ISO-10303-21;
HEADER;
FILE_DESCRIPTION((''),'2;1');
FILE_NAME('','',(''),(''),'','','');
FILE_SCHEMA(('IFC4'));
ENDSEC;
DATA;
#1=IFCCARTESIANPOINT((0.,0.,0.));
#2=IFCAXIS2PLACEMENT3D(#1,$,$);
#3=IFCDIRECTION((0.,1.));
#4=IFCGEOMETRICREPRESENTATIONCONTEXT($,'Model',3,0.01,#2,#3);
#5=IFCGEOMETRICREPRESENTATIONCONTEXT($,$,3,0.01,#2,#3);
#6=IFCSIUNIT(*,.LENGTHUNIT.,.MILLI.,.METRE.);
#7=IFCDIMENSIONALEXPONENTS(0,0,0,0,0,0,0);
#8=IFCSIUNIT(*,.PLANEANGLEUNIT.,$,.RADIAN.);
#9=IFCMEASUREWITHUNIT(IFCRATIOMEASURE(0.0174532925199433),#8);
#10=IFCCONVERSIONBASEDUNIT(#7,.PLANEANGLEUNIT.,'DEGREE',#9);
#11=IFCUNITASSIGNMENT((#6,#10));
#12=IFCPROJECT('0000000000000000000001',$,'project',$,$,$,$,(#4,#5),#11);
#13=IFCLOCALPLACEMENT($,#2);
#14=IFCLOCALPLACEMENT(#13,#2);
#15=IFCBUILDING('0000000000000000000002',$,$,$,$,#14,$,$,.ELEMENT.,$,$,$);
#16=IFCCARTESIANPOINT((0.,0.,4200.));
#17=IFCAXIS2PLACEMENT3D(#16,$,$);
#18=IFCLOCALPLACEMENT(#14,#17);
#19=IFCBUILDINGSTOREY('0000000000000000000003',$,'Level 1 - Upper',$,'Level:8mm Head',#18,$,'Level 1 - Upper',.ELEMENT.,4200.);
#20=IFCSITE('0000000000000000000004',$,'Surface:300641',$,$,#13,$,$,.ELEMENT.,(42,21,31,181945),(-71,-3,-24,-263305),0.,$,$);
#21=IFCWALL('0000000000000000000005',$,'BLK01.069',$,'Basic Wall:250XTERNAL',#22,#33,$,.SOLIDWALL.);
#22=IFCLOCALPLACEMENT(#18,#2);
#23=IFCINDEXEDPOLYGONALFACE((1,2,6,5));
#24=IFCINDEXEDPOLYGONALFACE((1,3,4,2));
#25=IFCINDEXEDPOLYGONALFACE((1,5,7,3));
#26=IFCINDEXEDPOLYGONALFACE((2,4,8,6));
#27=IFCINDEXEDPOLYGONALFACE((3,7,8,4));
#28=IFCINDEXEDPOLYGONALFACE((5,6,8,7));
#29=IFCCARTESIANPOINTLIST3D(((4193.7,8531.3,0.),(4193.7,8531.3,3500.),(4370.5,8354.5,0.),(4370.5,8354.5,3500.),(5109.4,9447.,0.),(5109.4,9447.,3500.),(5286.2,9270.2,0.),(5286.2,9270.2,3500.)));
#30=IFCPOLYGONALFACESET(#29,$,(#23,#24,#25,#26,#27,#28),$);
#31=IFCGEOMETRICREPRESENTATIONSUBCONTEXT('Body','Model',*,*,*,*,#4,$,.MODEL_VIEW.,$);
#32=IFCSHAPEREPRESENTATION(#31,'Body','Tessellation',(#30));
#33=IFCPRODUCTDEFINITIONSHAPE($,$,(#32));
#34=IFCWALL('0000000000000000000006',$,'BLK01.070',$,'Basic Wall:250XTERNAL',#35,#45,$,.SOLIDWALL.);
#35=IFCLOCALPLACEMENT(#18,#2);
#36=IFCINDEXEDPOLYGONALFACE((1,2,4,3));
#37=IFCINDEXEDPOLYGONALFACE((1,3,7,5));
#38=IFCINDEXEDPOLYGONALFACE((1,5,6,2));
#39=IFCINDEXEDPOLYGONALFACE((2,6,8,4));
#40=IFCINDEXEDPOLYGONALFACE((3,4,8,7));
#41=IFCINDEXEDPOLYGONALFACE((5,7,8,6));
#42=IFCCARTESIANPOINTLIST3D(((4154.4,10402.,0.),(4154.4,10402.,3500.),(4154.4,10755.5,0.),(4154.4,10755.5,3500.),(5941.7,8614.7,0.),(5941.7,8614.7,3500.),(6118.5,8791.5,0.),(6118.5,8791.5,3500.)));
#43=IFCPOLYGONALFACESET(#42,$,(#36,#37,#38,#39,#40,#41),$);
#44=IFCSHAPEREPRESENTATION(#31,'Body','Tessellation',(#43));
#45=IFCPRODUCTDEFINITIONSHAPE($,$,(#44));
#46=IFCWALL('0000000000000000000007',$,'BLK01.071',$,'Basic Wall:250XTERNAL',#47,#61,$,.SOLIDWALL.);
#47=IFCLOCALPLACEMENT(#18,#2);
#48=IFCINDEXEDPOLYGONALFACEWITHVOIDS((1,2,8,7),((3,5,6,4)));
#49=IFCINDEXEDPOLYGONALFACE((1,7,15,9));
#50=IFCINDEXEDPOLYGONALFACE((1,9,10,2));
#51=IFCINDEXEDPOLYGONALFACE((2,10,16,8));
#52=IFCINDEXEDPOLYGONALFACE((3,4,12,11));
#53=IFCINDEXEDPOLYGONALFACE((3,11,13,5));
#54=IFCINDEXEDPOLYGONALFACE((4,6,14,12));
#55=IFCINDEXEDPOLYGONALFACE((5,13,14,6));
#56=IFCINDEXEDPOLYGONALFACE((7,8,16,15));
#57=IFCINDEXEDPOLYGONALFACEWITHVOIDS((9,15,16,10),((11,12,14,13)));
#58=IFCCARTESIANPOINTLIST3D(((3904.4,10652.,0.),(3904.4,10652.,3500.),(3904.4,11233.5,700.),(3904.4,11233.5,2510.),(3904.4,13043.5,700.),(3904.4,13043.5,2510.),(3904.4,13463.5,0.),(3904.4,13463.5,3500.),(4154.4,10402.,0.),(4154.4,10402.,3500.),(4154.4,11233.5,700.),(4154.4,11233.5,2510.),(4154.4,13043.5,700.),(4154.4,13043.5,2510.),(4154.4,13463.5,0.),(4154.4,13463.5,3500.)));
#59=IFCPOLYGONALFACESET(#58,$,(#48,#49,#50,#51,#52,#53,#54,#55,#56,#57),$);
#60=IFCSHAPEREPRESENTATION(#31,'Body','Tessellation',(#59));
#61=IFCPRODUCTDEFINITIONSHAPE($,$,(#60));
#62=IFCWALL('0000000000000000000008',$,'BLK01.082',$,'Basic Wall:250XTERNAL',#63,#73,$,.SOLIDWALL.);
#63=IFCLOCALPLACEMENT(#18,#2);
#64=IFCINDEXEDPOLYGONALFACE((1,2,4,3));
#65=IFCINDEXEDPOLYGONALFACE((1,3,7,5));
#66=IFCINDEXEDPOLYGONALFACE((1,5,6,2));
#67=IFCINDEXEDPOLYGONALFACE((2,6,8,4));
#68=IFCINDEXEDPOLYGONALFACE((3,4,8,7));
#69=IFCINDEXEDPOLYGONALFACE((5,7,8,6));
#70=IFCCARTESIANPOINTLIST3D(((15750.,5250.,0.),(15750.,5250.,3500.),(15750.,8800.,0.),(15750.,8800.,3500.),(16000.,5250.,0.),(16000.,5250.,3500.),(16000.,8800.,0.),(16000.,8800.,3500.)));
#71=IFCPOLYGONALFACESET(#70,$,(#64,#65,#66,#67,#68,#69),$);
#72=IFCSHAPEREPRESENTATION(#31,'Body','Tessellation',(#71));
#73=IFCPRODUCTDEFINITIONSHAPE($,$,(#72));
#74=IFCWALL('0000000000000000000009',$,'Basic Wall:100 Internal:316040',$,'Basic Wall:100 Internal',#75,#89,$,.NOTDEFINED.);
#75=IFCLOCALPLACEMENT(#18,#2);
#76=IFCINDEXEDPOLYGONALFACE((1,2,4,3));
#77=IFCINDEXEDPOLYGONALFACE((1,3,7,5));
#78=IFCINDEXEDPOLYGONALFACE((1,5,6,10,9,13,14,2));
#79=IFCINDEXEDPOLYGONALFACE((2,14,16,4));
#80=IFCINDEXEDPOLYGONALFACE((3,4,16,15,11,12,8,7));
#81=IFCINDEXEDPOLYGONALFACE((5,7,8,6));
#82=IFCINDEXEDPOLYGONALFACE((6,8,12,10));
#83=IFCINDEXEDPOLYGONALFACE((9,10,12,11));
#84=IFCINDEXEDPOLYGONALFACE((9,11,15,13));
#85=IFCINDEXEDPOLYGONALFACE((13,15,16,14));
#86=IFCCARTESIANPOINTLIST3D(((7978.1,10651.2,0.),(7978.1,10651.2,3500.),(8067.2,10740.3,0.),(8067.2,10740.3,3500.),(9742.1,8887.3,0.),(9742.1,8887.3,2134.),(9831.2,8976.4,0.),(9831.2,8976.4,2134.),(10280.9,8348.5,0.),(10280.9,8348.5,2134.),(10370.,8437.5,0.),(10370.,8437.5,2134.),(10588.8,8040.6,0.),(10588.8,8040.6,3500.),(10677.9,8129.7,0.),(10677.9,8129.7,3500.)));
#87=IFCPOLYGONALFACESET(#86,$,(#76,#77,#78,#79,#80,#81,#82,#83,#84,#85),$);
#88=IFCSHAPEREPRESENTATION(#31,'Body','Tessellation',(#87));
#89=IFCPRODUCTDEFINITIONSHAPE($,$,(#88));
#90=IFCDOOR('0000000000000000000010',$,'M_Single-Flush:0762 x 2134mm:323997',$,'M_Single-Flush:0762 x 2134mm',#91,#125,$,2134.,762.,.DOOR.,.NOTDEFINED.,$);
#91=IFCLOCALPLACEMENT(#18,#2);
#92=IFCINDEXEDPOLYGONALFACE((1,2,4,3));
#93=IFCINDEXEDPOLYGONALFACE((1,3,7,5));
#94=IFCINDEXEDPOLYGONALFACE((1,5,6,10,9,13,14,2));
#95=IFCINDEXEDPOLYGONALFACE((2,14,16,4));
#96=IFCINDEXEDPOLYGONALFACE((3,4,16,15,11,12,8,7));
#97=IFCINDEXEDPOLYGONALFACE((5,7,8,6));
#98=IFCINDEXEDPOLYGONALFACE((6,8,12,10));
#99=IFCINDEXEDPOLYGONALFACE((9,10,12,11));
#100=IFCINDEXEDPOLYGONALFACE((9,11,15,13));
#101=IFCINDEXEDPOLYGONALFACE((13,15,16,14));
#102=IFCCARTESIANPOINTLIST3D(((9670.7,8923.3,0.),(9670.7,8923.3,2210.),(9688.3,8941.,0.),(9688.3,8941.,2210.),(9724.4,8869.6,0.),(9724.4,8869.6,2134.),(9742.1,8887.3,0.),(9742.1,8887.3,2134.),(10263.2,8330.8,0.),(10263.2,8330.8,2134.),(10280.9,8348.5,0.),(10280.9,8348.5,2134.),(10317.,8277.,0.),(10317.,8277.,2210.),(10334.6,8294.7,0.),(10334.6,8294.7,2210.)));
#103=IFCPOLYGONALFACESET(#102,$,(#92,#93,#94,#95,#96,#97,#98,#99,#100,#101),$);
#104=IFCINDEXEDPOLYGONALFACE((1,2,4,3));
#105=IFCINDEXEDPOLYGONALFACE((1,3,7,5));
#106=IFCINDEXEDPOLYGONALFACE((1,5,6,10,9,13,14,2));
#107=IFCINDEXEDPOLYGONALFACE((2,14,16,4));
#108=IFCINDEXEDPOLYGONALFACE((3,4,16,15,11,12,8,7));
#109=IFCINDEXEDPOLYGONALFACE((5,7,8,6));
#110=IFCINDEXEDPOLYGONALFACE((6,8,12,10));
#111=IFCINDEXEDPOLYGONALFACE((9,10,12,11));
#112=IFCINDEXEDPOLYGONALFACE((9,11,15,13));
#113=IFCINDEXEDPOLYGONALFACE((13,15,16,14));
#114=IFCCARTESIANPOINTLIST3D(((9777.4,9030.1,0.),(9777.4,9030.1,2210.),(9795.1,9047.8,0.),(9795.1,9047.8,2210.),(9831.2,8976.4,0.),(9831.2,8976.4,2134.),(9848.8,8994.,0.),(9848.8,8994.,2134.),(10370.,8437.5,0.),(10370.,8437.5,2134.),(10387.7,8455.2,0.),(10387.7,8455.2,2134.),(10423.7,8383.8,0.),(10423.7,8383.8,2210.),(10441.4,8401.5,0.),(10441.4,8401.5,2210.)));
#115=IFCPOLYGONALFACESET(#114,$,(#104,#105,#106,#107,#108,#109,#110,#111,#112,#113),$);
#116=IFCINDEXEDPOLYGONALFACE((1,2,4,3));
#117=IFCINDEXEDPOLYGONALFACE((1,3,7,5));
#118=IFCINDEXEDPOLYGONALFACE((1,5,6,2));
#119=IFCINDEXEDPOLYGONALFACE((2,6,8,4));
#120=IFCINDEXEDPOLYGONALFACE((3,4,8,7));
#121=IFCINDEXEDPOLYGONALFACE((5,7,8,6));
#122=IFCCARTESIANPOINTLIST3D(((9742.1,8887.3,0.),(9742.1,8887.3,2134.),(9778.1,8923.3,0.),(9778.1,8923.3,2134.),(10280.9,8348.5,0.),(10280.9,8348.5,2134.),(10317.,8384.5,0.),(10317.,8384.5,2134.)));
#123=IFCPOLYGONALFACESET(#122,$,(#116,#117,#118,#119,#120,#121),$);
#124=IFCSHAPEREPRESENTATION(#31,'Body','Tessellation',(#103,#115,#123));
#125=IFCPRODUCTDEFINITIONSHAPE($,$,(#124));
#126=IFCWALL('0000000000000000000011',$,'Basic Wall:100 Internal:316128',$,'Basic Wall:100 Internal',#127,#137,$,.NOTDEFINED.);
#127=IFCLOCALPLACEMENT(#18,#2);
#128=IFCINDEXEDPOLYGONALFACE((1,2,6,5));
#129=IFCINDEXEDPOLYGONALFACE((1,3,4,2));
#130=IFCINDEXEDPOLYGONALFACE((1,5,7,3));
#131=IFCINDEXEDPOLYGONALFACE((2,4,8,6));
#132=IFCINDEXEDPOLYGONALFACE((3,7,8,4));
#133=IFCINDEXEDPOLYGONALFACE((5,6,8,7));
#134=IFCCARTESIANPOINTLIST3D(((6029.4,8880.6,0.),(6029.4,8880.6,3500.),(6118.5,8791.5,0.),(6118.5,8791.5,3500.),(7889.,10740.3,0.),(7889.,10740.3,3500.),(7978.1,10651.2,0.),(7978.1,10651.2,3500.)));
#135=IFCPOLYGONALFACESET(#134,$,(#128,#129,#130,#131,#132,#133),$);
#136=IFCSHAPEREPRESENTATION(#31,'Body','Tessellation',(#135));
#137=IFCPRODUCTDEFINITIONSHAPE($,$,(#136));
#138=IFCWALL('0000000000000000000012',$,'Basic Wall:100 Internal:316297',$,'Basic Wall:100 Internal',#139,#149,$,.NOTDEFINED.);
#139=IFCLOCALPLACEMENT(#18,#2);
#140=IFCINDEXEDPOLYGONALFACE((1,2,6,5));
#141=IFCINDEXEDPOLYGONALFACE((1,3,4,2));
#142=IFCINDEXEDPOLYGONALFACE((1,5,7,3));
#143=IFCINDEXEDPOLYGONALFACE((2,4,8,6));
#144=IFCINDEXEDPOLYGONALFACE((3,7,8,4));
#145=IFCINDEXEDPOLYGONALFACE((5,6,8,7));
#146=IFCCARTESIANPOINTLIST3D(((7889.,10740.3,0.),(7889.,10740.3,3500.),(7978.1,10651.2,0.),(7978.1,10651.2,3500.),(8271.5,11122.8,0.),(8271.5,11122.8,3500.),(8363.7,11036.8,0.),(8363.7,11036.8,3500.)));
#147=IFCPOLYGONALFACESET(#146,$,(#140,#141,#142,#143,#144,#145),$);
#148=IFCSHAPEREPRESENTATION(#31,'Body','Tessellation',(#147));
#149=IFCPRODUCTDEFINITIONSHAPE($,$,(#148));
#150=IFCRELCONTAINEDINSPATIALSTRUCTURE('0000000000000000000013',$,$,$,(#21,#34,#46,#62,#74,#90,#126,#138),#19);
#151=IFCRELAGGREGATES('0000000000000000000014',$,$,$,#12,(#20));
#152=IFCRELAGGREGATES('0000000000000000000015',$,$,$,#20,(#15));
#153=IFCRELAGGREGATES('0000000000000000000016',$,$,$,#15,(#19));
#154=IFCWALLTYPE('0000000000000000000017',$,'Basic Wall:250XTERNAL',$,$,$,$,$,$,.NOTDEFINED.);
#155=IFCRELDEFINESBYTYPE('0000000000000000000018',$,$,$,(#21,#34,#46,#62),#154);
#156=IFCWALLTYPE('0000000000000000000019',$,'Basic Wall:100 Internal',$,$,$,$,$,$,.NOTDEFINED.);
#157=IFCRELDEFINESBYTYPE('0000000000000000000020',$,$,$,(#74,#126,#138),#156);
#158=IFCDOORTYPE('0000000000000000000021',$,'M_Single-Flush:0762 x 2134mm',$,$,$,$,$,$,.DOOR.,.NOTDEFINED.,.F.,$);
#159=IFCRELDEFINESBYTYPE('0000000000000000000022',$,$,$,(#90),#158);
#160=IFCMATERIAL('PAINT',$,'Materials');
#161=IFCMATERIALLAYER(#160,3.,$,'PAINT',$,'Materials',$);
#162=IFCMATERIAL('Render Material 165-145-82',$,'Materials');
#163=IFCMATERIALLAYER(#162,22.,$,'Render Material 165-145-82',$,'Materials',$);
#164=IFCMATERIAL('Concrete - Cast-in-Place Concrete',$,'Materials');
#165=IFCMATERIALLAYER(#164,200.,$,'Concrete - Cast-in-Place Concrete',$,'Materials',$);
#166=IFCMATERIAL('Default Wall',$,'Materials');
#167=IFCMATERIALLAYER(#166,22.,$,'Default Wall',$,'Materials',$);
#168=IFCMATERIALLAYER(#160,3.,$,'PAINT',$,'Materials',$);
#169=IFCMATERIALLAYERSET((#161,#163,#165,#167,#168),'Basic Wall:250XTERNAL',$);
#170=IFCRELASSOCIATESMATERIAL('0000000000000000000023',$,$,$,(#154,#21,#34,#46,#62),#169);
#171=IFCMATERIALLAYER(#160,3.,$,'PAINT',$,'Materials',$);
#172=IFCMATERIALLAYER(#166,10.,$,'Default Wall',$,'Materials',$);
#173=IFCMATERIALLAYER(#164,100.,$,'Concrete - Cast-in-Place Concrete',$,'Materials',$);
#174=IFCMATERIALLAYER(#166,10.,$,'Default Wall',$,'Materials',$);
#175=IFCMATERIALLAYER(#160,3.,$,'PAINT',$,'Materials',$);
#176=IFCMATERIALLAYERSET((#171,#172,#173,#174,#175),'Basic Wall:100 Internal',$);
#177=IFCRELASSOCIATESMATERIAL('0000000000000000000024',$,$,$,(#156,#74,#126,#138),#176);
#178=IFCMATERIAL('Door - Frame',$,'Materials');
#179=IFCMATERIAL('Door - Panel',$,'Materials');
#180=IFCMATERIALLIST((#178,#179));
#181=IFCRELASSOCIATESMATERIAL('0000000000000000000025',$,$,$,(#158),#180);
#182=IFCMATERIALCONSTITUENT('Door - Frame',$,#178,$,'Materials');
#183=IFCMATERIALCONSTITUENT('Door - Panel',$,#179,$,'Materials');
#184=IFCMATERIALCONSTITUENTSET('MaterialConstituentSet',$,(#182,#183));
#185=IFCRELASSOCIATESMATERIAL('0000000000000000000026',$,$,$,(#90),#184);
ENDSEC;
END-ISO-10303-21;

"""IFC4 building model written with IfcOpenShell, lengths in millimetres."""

from ifc_helpers import new_model, entity, si_unit, converted_unit, direction, frame, frame_2d, origin, place, context, subcontext, project, spatial, polyline, rectangle, outline, extrude, clip, halfspace, source, transform, mapped, material, material_list, layer, layer_set, layer_usage, constituent, constituent_set, type_object, type_shapes, element, fill, save


model = new_model("IFC4")

# Units and contexts
model_context = context("Model", 3, precision=0.01, world=origin(), true_north=direction((0.0, 1.0)))
context_of_model = context(None, 3, precision=0.01, world=origin(), true_north=direction((0.0, 1.0)))
body_context = subcontext(model_context, "Body", "Model", "MODEL_VIEW")
ifc_project = project(units=[si_unit("LENGTHUNIT", "METRE", prefix="MILLI"), converted_unit("PLANEANGLEUNIT", "DEGREE", entity("IfcRatioMeasure", 0.0174532925199433), si_unit("PLANEANGLEUNIT", "RADIAN"), dimensions=[0, 0, 0, 0, 0, 0, 0])], contexts=[model_context, context_of_model])

# Site, building, storey
site_placement = place(None, origin())
site = spatial("IfcSite", under=ifc_project, at=site_placement, Name="Surface:300641", CompositionType="ELEMENT", RefLatitude=(42, 21, 31, 181945), RefLongitude=(-71, -3, -24, -263305), RefElevation=0.0)
building_placement = place(site_placement, origin())
building = spatial("IfcBuilding", under=site, at=building_placement, CompositionType="ELEMENT")
storey_placement = place(building_placement, frame((0.0, 0.0, 4200.0)))
storey = spatial("IfcBuildingStorey", under=building, at=storey_placement, Name="Level 1 - Upper", ObjectType="Level:8mm Head", LongName="Level 1 - Upper", CompositionType="ELEMENT", Elevation=4200.0)

# Shared definitions
ifc_material_1 = material(Name="PAINT", Category="Materials")
ifc_layer_1 = layer(ifc_material_1, 3.0, Name="PAINT", Category="Materials")
ifc_material_2 = material(Name="Render Material 165-145-82", Category="Materials")
ifc_layer_2 = layer(ifc_material_2, 22.0, Name="Render Material 165-145-82", Category="Materials")
ifc_material_3 = material(Name="Concrete - Cast-in-Place Concrete", Category="Materials")
ifc_layer_3 = layer(ifc_material_3, 200.0, Name="Concrete - Cast-in-Place Concrete", Category="Materials")
ifc_material_4 = material(Name="Default Wall", Category="Materials")
ifc_layer_4 = layer(ifc_material_4, 22.0, Name="Default Wall", Category="Materials")
ifc_layer_5 = layer(ifc_material_1, 3.0, Name="PAINT", Category="Materials")
ifc_layer_set_1 = layer_set([ifc_layer_1, ifc_layer_2, ifc_layer_3, ifc_layer_4, ifc_layer_5], Name="Basic Wall:250XTERNAL")
wall_type_1 = type_object("IfcWallType", Name="Basic Wall:250XTERNAL", PredefinedType="NOTDEFINED", material=ifc_layer_set_1)

# Walls
ifc_layer_usage_1 = layer_usage(ifc_layer_set_1, "AXIS2", "NEGATIVE", 125.0)
wall_1_placement = place(storey_placement, frame((4282.1, 8442.9, 0.0), z_axis=(0.0, 0.0, 1.0), x_axis=(0.707107, 0.707107, 0.0)))
element("IfcWall", 1, at=wall_1_placement, inside=storey, type_object=wall_type_1, material=ifc_layer_usage_1, Name="BLK01.069", ObjectType="Basic Wall:250XTERNAL", PredefinedType="SOLIDWALL", context=body_context, shape_type="Clipping", body=[
    clip(extrude(rectangle(XDim=1295.0, YDim=250.0, at=frame_2d((647.5, 0.0), x_axis=(-1.0, 0.0))), origin(), (0.0, 0.0, 1.0), 3500.0), halfspace(origin(), True)),
])
ifc_layer_usage_2 = layer_usage(ifc_layer_set_1, "AXIS2", "NEGATIVE", 125.0)
wall_2_placement = place(storey_placement, frame((6030.1, 8703.1, 0.0), z_axis=(0.0, 0.0, 1.0), x_axis=(-0.707107, 0.707107, 0.0)))
element("IfcWall", 2, at=wall_2_placement, inside=storey, type_object=wall_type_1, material=ifc_layer_usage_2, Name="BLK01.070", ObjectType="Basic Wall:250XTERNAL", PredefinedType="SOLIDWALL", context=body_context, shape_type="Clipping", body=[
    clip(extrude(outline(polyline([(2777.5, -125.0), (2527.5, 125.0), (1177.0, 125.0), (927.0, 125.0), (0.0, 125.0), (0.0, -125.0), (126.0, -125.0), (2777.5, -125.0)])), origin(), (0.0, 0.0, 1.0), 3500.0), halfspace(origin(), True)),
])

# Wall, opening
ifc_layer_usage_3 = layer_usage(ifc_layer_set_1, "AXIS2", "NEGATIVE", 125.0)
wall_3_placement = place(storey_placement, frame((4029.4, 10402.0, 0.0), z_axis=(0.0, 0.0, 1.0), x_axis=(0.0, 1.0, 0.0)))
wall_3 = element("IfcWall", 3, at=wall_3_placement, inside=storey, type_object=wall_type_1, material=ifc_layer_usage_3, Name="BLK01.071", ObjectType="Basic Wall:250XTERNAL", PredefinedType="SOLIDWALL", context=body_context, shape_type="Clipping", body=[
    clip(extrude(outline(polyline([(3061.5, -125.0), (3061.5, 125.0), (250.0, 125.0), (0.0, -125.0), (353.6, -125.0), (2811.5, -125.0), (3061.5, -125.0)])), origin(), (0.0, 0.0, 1.0), 3500.0), halfspace(origin(), True)),
])
opening_1_placement = place(wall_3_placement, frame((831.5, -125.0, 700.0)))
element("IfcOpeningElement", 4, at=opening_1_placement, cuts=wall_3, ObjectType="Opening", PredefinedType="OPENING", context=body_context, shape_type="SweptSolid", body=[
    extrude(rectangle(XDim=1810.0, YDim=1810.0, at=frame_2d((905.0, 905.0), x_axis=(-1.0, 0.0))), frame((0.0, 0.0, 0.0), z_axis=(0.0, 1.0, 0.0), x_axis=(0.0, 0.0, 1.0)), (0.0, 0.0, 1.0), 250.0),
])

# Wall
ifc_layer_usage_4 = layer_usage(ifc_layer_set_1, "AXIS2", "POSITIVE", -125.0)
wall_4_placement = place(storey_placement, frame((15875.0, 5250.0, 0.0), z_axis=(0.0, 0.0, 1.0), x_axis=(0.0, 1.0, 0.0)))
element("IfcWall", 5, at=wall_4_placement, inside=storey, type_object=wall_type_1, material=ifc_layer_usage_4, Name="BLK01.082", ObjectType="Basic Wall:250XTERNAL", PredefinedType="SOLIDWALL", context=body_context, shape_type="Clipping", body=[
    clip(extrude(rectangle(XDim=3550.0, YDim=250.0, at=frame_2d((1775.0, 0.0), x_axis=(-1.0, 0.0))), origin(), (0.0, 0.0, 1.0), 3500.0), halfspace(origin(), True)),
])
ifc_layer_6 = layer(ifc_material_1, 3.0, Name="PAINT", Category="Materials")
ifc_layer_7 = layer(ifc_material_4, 10.0, Name="Default Wall", Category="Materials")
ifc_layer_8 = layer(ifc_material_3, 100.0, Name="Concrete - Cast-in-Place Concrete", Category="Materials")
ifc_layer_9 = layer(ifc_material_4, 10.0, Name="Default Wall", Category="Materials")
ifc_layer_10 = layer(ifc_material_1, 3.0, Name="PAINT", Category="Materials")
ifc_layer_set_2 = layer_set([ifc_layer_6, ifc_layer_7, ifc_layer_8, ifc_layer_9, ifc_layer_10], Name="Basic Wall:100 Internal")
wall_type_2 = type_object("IfcWallType", Name="Basic Wall:100 Internal", PredefinedType="NOTDEFINED", material=ifc_layer_set_2)

# Wall, opening, door
ifc_layer_usage_5 = layer_usage(ifc_layer_set_2, "AXIS2", "POSITIVE", -63.0)
wall_5_placement = place(storey_placement, frame((8022.7, 10695.7, 0.0), z_axis=(0.0, 0.0, 1.0), x_axis=(0.707107, -0.707107, 0.0)))
wall_5 = element("IfcWall", 6, at=wall_5_placement, inside=storey, type_object=wall_type_2, material=ifc_layer_usage_5, Name="Basic Wall:100 Internal:316040", ObjectType="Basic Wall:100 Internal", PredefinedType="NOTDEFINED", context=body_context, shape_type="Clipping", body=[
    clip(extrude(rectangle(XDim=3692.0, YDim=126.0, at=frame_2d((1846.0, 0.0), x_axis=(-1.0, 0.0))), origin(), (0.0, 0.0, 1.0), 3500.0), halfspace(origin(), True)),
])
opening_2_placement = place(wall_5_placement, frame((3256.6, 63.0, 0.0)))
opening_2 = element("IfcOpeningElement", 7, at=opening_2_placement, cuts=wall_5, ObjectType="Opening", PredefinedType="OPENING", context=body_context, shape_type="SweptSolid", body=[
    extrude(rectangle(XDim=762.0, YDim=2134.0, at=frame_2d((1067.0, 381.0), x_axis=(0.0, -1.0))), frame((0.0, 0.0, 0.0), z_axis=(0.0, -1.0, 0.0), x_axis=(0.0, 0.0, 1.0)), (0.0, 0.0, 1.0), 126.0),
])
ifc_material_5 = material(Name="Door - Frame", Category="Materials")
ifc_constituent_1 = constituent(ifc_material_5, Name="Door - Frame", Category="Materials")
ifc_material_6 = material(Name="Door - Panel", Category="Materials")
ifc_constituent_2 = constituent(ifc_material_6, Name="Door - Panel", Category="Materials")
ifc_constituent_set_1 = constituent_set(constituents=[ifc_constituent_1, ifc_constituent_2], Name="MaterialConstituentSet")
ifc_material_list = material_list([ifc_material_5, ifc_material_6])
door_type = type_object("IfcDoorType", Name="M_Single-Flush:0762 x 2134mm", OperationType="NOTDEFINED", ParameterTakesPrecedence=False, PredefinedType="DOOR", material=ifc_material_list)
shared_shape_1 = source(origin(), body_context, "Body", "SweptSolid", [
    extrude(outline(polyline([(-457.0, -1124.0), (457.0, -1124.0), (457.0, 1086.0), (381.0, 1086.0), (381.0, -1048.0), (-381.0, -1048.0), (-381.0, 1086.0), (-457.0, 1086.0), (-457.0, -1124.0)])), frame((381.0, 151.0, 1086.0), z_axis=(0.0, -1.0, 0.0), x_axis=(-1.0, 0.0, 0.0)), (0.0, 0.0, 1.0), 25.0),
    extrude(outline(polyline([(-1124.0, -457.0), (1086.0, -457.0), (1086.0, -381.0), (-1048.0, -381.0), (-1048.0, 381.0), (1086.0, 381.0), (1086.0, 457.0), (-1124.0, 457.0), (-1124.0, -457.0)])), frame((381.0, 0.0, 1086.0), z_axis=(0.0, -1.0, 0.0), x_axis=(0.0, 0.0, -1.0)), (0.0, 0.0, 1.0), 25.0),
    extrude(rectangle(XDim=762.0, YDim=51.0, at=frame_2d((0.0, 0.0), x_axis=(1.0, 0.0))), frame((381.0, 100.5, 0.0)), (0.0, 0.0, 1.0), 2134.0),
])
type_shapes(door_type, [shared_shape_1])
door_1_placement = place(opening_2_placement, frame((0.0, 0.0, 0.0), z_axis=(0.0, 0.0, 1.0), x_axis=(-1.0, 0.0, 0.0)))
door_1 = element("IfcDoor", 8, at=door_1_placement, inside=storey, type_object=door_type, material=ifc_constituent_set_1, Name="M_Single-Flush:0762 x 2134mm:323997", ObjectType="M_Single-Flush:0762 x 2134mm", OperationType="NOTDEFINED", OverallHeight=2134.0, OverallWidth=762.0, PredefinedType="DOOR", context=body_context, shape_type="MappedRepresentation", body=[
    mapped(shared_shape_1, transform((0.0, 0.0, 0.0), scale=1.0)),
])
fill(opening_2, door_1)

# Walls
ifc_layer_usage_6 = layer_usage(ifc_layer_set_2, "AXIS2", "NEGATIVE", 63.0)
wall_6_placement = place(storey_placement, frame((6073.9, 8836.1, 0.0), z_axis=(0.0, 0.0, 1.0), x_axis=(0.707107, 0.707107, 0.0)))
element("IfcWall", 9, at=wall_6_placement, inside=storey, type_object=wall_type_2, material=ifc_layer_usage_6, Name="Basic Wall:100 Internal:316128", ObjectType="Basic Wall:100 Internal", PredefinedType="NOTDEFINED", context=body_context, shape_type="Clipping", body=[
    clip(extrude(rectangle(XDim=2630.0, YDim=126.0, at=frame_2d((1315.0, 0.0), x_axis=(-1.0, 0.0))), origin(), (0.0, 0.0, 1.0), 3500.0), halfspace(origin(), True)),
])
ifc_layer_usage_7 = layer_usage(ifc_layer_set_2, "AXIS2", "NEGATIVE", 63.0)
wall_7_placement = place(storey_placement, frame((7933.6, 10695.7, 0.0), z_axis=(0.0, 0.0, 1.0), x_axis=(0.707107, 0.707107, 0.0)))
element("IfcWall", 10, at=wall_7_placement, inside=storey, type_object=wall_type_2, material=ifc_layer_usage_7, Name="Basic Wall:100 Internal:316297", ObjectType="Basic Wall:100 Internal", PredefinedType="NOTDEFINED", context=body_context, shape_type="Clipping", body=[
    clip(extrude(outline(polyline([(545.3, -63.0), (540.9, 63.0), (0.0, 63.0), (0.0, -63.0), (126.0, -63.0), (419.2, -63.0), (545.3, -63.0)])), origin(), (0.0, 0.0, 1.0), 3500.0), halfspace(origin(), True)),
])

save(model, "model.ifc")
